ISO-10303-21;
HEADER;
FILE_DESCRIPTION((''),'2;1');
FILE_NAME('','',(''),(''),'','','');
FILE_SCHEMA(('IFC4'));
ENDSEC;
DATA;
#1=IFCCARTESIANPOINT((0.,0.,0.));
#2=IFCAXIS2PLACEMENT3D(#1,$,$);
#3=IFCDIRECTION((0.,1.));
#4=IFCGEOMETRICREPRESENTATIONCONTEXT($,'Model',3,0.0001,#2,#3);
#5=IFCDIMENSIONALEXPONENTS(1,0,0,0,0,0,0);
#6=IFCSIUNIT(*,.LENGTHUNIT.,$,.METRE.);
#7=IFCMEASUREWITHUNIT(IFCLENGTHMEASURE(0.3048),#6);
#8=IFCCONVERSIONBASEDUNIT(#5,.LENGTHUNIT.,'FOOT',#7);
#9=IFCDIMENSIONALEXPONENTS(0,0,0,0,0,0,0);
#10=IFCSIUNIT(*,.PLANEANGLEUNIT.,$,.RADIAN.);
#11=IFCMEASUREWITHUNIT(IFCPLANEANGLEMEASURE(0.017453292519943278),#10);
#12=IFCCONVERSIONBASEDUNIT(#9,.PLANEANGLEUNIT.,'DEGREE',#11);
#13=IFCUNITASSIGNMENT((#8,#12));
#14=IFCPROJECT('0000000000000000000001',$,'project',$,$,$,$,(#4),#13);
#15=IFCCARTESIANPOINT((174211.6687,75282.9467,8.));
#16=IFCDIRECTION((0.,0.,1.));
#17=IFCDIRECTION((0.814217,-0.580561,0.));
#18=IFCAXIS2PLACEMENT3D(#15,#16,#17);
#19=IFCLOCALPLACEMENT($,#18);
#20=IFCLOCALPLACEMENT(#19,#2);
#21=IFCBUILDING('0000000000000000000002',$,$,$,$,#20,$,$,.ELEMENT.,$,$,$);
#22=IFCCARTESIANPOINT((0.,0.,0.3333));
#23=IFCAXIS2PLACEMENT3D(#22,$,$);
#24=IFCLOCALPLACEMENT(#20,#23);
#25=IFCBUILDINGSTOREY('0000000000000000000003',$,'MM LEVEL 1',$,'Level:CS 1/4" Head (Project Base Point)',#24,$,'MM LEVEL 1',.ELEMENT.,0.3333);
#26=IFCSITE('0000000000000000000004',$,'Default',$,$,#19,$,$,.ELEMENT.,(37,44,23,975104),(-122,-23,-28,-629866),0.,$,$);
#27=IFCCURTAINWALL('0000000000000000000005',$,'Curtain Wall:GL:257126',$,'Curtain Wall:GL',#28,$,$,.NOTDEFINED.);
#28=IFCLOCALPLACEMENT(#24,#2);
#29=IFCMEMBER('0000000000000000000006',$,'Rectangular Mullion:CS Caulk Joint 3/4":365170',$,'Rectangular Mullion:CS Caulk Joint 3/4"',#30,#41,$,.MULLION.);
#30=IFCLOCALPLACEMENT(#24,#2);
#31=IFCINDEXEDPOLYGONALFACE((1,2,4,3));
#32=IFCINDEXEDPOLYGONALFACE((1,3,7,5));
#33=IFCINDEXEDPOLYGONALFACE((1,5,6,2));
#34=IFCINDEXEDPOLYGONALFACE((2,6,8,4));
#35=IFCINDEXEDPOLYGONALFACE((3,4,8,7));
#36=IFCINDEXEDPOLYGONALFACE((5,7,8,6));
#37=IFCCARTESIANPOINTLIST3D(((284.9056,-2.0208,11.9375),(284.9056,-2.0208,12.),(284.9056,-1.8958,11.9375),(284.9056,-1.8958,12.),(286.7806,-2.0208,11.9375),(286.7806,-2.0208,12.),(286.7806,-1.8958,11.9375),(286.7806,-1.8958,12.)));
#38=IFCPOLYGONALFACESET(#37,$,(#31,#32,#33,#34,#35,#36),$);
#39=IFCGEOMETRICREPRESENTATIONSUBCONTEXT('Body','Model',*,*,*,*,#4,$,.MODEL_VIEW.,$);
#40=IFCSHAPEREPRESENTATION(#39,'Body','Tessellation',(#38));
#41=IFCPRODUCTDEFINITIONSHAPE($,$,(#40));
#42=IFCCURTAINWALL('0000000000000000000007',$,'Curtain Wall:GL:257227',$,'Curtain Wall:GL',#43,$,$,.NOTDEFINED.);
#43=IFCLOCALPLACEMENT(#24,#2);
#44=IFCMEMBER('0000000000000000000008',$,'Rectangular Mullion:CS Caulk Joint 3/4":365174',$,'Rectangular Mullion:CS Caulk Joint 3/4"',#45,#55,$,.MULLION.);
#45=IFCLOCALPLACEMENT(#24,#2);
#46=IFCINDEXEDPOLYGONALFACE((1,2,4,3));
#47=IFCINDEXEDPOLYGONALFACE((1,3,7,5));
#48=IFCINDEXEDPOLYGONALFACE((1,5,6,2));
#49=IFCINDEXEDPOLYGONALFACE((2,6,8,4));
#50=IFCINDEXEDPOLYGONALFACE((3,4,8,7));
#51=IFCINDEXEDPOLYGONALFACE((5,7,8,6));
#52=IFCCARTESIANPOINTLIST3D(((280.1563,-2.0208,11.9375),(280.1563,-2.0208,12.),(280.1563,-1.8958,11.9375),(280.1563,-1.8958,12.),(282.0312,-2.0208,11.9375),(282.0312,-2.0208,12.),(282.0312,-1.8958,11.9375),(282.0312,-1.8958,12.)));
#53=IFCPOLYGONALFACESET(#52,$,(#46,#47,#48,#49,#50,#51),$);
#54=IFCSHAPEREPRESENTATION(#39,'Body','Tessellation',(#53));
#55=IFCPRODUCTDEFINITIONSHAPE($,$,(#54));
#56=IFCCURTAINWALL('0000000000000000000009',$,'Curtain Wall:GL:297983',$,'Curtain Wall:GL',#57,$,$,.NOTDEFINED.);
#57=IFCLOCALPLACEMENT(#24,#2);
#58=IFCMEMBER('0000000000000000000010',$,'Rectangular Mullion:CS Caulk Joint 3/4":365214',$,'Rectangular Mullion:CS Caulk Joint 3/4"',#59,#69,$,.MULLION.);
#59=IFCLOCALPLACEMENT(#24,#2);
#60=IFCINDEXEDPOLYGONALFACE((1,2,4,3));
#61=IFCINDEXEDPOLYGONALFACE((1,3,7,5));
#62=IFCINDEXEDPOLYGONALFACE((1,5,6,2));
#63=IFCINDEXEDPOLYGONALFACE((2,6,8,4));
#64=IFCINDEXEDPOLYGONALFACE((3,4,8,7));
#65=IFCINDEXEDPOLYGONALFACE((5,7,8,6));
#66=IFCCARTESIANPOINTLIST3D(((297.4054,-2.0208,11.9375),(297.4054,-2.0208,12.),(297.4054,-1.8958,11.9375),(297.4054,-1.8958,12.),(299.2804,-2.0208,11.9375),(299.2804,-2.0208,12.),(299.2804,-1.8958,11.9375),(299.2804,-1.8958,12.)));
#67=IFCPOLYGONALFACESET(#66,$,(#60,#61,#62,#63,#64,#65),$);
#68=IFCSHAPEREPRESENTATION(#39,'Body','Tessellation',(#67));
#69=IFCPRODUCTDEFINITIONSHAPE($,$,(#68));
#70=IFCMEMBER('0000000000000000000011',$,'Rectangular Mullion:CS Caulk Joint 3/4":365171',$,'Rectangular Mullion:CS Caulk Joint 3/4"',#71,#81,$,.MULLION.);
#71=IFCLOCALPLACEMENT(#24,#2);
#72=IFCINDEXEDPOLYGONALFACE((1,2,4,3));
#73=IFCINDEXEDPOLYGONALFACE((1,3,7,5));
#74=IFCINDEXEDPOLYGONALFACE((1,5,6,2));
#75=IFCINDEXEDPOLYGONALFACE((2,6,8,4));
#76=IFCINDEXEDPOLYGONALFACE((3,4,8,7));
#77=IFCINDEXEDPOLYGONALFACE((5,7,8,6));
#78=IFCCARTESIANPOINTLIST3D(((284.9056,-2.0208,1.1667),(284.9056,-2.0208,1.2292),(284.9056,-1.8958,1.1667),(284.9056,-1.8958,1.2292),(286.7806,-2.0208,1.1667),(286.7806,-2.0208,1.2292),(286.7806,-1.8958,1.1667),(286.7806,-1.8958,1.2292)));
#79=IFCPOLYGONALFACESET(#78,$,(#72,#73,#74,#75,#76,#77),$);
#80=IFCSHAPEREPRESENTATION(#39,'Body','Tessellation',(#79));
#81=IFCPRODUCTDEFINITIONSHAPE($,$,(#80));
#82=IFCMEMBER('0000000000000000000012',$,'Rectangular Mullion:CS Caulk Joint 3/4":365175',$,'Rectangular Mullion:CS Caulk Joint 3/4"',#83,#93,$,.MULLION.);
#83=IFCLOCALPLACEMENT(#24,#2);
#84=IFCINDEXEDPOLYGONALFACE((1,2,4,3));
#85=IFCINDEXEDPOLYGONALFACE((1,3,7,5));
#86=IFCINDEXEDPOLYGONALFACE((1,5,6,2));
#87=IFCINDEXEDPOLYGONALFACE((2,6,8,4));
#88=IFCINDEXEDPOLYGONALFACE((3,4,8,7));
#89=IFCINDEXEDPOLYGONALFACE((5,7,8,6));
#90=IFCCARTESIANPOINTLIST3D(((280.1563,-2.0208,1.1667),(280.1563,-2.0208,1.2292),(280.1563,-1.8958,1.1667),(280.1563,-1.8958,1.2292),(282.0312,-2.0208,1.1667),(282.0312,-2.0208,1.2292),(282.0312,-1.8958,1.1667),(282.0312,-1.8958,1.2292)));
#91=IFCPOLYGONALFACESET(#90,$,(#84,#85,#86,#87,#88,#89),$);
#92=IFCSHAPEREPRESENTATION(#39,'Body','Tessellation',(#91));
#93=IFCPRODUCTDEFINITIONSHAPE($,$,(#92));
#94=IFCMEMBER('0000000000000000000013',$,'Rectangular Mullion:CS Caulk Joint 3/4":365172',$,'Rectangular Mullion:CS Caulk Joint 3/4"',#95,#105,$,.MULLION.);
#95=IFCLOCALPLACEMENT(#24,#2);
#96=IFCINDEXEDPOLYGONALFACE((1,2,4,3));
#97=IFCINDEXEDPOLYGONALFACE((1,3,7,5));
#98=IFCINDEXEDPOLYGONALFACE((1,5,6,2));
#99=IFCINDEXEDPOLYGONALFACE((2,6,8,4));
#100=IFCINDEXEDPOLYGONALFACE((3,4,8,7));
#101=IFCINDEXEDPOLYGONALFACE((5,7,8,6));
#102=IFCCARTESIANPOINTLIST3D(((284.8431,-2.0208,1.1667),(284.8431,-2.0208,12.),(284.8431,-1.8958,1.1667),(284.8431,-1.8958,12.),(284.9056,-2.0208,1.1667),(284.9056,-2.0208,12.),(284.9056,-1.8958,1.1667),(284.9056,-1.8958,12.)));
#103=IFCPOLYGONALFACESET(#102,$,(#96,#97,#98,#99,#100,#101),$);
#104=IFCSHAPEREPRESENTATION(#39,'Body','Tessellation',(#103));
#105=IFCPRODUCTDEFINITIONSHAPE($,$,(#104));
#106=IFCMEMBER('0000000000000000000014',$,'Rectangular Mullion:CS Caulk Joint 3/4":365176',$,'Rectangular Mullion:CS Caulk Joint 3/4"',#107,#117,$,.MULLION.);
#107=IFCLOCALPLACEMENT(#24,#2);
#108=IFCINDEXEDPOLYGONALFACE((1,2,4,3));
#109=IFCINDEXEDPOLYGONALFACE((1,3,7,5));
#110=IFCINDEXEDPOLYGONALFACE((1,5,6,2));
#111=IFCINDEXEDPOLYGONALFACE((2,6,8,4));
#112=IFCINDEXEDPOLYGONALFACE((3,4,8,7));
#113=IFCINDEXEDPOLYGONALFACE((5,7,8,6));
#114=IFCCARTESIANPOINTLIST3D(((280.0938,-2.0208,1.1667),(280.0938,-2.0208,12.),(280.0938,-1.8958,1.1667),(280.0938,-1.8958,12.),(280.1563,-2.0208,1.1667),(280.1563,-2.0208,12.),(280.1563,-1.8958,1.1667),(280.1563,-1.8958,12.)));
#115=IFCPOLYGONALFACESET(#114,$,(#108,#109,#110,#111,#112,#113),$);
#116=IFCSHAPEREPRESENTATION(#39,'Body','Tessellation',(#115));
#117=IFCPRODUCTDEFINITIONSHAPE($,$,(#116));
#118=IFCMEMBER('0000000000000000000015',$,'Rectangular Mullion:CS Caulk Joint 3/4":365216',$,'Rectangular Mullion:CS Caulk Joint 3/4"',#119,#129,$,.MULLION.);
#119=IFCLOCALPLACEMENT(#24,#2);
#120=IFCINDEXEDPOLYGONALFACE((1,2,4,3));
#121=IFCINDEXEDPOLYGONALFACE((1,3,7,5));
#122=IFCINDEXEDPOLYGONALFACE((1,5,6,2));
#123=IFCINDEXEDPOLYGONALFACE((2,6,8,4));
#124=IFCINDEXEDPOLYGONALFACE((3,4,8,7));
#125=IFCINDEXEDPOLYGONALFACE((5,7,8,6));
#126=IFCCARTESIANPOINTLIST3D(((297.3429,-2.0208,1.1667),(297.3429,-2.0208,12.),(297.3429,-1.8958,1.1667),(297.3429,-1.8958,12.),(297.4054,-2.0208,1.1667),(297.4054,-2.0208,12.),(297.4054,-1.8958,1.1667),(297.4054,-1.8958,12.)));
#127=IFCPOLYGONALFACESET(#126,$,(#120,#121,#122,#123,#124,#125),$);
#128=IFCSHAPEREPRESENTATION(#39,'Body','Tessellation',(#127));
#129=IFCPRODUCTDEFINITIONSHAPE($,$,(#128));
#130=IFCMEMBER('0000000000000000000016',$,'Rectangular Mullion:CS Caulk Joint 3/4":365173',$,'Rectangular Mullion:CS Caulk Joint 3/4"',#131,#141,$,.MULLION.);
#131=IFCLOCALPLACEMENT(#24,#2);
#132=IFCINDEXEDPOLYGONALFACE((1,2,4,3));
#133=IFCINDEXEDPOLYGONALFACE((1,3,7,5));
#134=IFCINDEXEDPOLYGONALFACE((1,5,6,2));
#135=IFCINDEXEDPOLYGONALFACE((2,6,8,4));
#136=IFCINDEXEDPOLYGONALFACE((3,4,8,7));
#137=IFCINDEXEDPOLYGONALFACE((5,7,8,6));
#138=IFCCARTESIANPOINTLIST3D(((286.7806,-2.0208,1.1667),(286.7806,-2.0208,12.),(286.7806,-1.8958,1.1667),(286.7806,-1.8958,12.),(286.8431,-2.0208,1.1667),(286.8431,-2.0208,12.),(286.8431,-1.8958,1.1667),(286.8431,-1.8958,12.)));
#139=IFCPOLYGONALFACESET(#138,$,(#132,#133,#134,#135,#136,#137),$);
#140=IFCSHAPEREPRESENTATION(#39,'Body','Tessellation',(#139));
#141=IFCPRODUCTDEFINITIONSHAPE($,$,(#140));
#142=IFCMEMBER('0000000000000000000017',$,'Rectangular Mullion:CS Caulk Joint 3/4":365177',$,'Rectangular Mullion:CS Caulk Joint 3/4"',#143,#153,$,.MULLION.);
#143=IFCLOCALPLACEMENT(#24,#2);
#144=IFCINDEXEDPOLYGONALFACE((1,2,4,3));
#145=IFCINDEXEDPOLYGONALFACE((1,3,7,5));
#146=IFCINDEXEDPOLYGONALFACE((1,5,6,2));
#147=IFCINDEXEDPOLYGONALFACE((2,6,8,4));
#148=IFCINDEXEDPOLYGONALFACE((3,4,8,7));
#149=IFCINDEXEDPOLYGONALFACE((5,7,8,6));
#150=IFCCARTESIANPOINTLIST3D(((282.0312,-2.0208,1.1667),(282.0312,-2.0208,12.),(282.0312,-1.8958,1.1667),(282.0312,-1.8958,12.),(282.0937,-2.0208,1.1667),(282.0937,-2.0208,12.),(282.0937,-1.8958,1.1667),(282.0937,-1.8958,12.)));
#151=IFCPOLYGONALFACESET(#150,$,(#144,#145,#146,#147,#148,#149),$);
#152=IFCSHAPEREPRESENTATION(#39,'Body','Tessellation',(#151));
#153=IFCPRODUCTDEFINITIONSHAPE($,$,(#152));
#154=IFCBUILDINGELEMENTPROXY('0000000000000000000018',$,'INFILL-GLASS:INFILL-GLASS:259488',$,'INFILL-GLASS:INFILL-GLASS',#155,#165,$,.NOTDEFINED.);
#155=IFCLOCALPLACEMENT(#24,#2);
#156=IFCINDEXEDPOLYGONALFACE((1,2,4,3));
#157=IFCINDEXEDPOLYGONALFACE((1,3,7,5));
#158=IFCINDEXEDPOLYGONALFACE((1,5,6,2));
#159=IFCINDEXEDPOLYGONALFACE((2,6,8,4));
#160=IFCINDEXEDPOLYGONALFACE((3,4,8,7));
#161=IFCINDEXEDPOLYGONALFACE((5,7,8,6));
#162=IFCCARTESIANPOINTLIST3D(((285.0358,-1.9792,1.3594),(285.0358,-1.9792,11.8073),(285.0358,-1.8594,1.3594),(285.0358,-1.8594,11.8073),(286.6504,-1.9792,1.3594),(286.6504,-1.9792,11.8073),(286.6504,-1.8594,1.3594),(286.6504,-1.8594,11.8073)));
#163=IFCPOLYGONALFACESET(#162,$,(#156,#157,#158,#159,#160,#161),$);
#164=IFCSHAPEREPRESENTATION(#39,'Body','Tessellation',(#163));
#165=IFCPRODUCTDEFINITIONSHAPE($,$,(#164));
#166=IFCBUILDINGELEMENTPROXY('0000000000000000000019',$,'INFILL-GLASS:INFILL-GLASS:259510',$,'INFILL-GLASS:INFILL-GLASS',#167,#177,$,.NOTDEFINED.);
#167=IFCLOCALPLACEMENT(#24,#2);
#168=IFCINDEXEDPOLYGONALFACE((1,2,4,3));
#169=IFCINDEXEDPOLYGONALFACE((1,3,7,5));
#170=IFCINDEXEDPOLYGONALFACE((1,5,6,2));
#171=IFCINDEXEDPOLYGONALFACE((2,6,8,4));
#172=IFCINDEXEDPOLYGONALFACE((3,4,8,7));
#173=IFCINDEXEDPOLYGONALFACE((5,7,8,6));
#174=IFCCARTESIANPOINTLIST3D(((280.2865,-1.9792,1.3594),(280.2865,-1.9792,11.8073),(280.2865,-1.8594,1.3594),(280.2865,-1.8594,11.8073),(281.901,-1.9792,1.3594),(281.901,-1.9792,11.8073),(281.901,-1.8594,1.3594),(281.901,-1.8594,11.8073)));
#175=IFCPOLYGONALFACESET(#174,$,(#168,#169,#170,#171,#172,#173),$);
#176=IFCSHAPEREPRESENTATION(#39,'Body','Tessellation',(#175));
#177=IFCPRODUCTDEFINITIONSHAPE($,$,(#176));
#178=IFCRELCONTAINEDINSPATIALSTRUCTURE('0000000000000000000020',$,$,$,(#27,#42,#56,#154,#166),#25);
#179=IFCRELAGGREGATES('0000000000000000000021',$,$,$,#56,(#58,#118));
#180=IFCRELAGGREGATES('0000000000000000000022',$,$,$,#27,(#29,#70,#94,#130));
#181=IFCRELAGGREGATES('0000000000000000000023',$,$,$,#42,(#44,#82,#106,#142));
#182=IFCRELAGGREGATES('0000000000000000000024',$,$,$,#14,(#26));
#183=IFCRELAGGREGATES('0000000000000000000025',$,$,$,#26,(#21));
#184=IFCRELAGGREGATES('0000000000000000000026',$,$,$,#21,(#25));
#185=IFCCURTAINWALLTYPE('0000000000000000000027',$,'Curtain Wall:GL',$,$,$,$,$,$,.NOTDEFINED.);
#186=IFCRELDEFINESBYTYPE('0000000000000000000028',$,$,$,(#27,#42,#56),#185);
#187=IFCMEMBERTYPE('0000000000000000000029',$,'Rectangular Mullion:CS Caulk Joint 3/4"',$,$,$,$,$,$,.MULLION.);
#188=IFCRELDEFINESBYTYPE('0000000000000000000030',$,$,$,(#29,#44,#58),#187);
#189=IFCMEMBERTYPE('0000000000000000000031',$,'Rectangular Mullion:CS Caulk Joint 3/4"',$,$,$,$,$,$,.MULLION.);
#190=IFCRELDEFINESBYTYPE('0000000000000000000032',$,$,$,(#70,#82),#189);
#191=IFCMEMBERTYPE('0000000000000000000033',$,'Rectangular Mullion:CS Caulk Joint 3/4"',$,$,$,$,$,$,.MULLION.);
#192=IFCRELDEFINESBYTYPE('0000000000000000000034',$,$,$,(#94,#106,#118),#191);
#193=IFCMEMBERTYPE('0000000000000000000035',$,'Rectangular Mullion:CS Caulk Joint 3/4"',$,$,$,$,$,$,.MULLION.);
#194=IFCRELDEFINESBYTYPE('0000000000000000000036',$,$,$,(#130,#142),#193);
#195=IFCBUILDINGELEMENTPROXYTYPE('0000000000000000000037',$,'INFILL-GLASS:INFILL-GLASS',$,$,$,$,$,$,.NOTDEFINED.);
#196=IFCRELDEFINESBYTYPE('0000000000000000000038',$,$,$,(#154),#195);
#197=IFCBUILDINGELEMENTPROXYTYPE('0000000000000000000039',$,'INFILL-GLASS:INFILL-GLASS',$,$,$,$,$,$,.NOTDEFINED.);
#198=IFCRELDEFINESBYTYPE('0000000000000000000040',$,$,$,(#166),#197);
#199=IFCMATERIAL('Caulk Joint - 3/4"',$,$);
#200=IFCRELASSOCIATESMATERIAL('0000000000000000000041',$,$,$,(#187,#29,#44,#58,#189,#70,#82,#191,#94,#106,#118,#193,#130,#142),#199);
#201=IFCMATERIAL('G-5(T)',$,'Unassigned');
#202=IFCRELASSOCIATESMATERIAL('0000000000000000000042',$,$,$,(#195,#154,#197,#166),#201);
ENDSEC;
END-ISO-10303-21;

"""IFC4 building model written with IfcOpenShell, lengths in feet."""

from ifc_helpers import new_model, entity, si_unit, converted_unit, direction, frame, origin, place, context, subcontext, project, spatial, indexed_curve, outline, extrude, source, transform, mapped, material, type_object, type_shapes, element, aggregate, save


model = new_model("IFC4")

# Units and contexts
model_context = context("Model", 3, precision=0.0001, world=origin(), true_north=direction((0.0, 1.0)))
body_context = subcontext(model_context, "Body", "Model", "MODEL_VIEW")
ifc_project = project(units=[converted_unit("LENGTHUNIT", "FOOT", entity("IfcLengthMeasure", 0.3048), si_unit("LENGTHUNIT", "METRE"), dimensions=[1, 0, 0, 0, 0, 0, 0]), converted_unit("PLANEANGLEUNIT", "DEGREE", entity("IfcPlaneAngleMeasure", 0.017453292519943278), si_unit("PLANEANGLEUNIT", "RADIAN"), dimensions=[0, 0, 0, 0, 0, 0, 0])], contexts=[model_context])

# Site, building, storey
site_placement = place(None, frame((174211.6687, 75282.9467, 8.0), z_axis=(0.0, 0.0, 1.0), x_axis=(0.814217, -0.580561, 0.0)))
site = spatial("IfcSite", under=ifc_project, at=site_placement, Name="Default", CompositionType="ELEMENT", RefLatitude=(37, 44, 23, 975104), RefLongitude=(-122, -23, -28, -629866), RefElevation=0.0)
building_placement = place(site_placement, origin())
building = spatial("IfcBuilding", under=site, at=building_placement, CompositionType="ELEMENT")
storey_placement = place(building_placement, frame((0.0, 0.0, 0.3333)))
storey = spatial("IfcBuildingStorey", under=building, at=storey_placement, Name="MM LEVEL 1", ObjectType="Level:CS 1/4\" Head (Project Base Point)", LongName="MM LEVEL 1", CompositionType="ELEMENT", Elevation=0.3333)

# Curtain walls, members
curtain_wall_type_1 = type_object("IfcCurtainWallType", Name="Curtain Wall:GL", PredefinedType="NOTDEFINED")
curtain_wall_1_placement = place(storey_placement, frame((0.0, 0.0, -0.3333)))
curtain_wall_1 = element("IfcCurtainWall", 1, at=curtain_wall_1_placement, inside=storey, type_object=curtain_wall_type_1, Name="Curtain Wall:GL:257126", ObjectType="Curtain Wall:GL", PredefinedType="NOTDEFINED")
ifc_material_1 = material(Name="Caulk Joint - 3/4\"")
member_type_1 = type_object("IfcMemberType", Name="Rectangular Mullion:CS Caulk Joint 3/4\"", PredefinedType="MULLION", material=ifc_material_1)
shared_shape_1 = source(origin(), body_context, "Body", "SweptSolid", [
    extrude(outline(indexed_curve([(-0.0625, -0.0312), (0.0625, -0.0312), (0.0625, 0.0312), (-0.0625, 0.0312), (-0.0625, -0.0312)], self_intersect=False)), frame((-0.0312, 0.0625, -1.875), z_axis=(0.0, 0.0, 1.0), x_axis=(0.0, -1.0, 0.0)), (0.0, 0.0, 1.0), 1.875),
])
type_shapes(member_type_1, [shared_shape_1])
member_1_placement = place(curtain_wall_1_placement, frame((284.9056, -2.0208, 12.3333), z_axis=(-1.0, 0.0, 0.0), x_axis=(0.0, 0.0, 1.0)))
member_1 = element("IfcMember", 2, at=member_1_placement, type_object=member_type_1, material=ifc_material_1, Name="Rectangular Mullion:CS Caulk Joint 3/4\":365170", ObjectType="Rectangular Mullion:CS Caulk Joint 3/4\"", PredefinedType="MULLION", context=body_context, shape_type="MappedRepresentation", body=[
    mapped(shared_shape_1, transform((0.0, 0.0, 0.0), scale=1.0)),
])
curtain_wall_2_placement = place(storey_placement, frame((0.0, 0.0, -0.3333)))
curtain_wall_2 = element("IfcCurtainWall", 3, at=curtain_wall_2_placement, inside=storey, type_object=curtain_wall_type_1, Name="Curtain Wall:GL:257227", ObjectType="Curtain Wall:GL", PredefinedType="NOTDEFINED")
member_2_placement = place(curtain_wall_2_placement, frame((280.1562, -2.0208, 12.3333), z_axis=(-1.0, 0.0, 0.0), x_axis=(0.0, 0.0, 1.0)))
member_2 = element("IfcMember", 4, at=member_2_placement, type_object=member_type_1, material=ifc_material_1, Name="Rectangular Mullion:CS Caulk Joint 3/4\":365174", ObjectType="Rectangular Mullion:CS Caulk Joint 3/4\"", PredefinedType="MULLION", context=body_context, shape_type="MappedRepresentation", body=[
    mapped(shared_shape_1, transform((0.0, 0.0, 0.0), scale=1.0)),
])
curtain_wall_3_placement = place(storey_placement, frame((0.0, 0.0, -0.3333)))
curtain_wall_3 = element("IfcCurtainWall", 5, at=curtain_wall_3_placement, inside=storey, type_object=curtain_wall_type_1, Name="Curtain Wall:GL:297983", ObjectType="Curtain Wall:GL", PredefinedType="NOTDEFINED")
member_3_placement = place(curtain_wall_3_placement, frame((297.4054, -2.0208, 12.3333), z_axis=(-1.0, 0.0, 0.0), x_axis=(0.0, 0.0, 1.0)))
member_3 = element("IfcMember", 6, at=member_3_placement, type_object=member_type_1, material=ifc_material_1, Name="Rectangular Mullion:CS Caulk Joint 3/4\":365214", ObjectType="Rectangular Mullion:CS Caulk Joint 3/4\"", PredefinedType="MULLION", context=body_context, shape_type="MappedRepresentation", body=[
    mapped(shared_shape_1, transform((0.0, 0.0, 0.0), scale=1.0)),
])

# Members
member_type_2 = type_object("IfcMemberType", Name="Rectangular Mullion:CS Caulk Joint 3/4\"", PredefinedType="MULLION", material=ifc_material_1)
shared_shape_2 = source(origin(), body_context, "Body", "SweptSolid", [
    extrude(outline(indexed_curve([(-0.0312, -0.0625), (0.0312, -0.0625), (0.0312, 0.0625), (-0.0312, 0.0625), (-0.0312, -0.0625)], self_intersect=False)), frame((-0.0312, 0.0625, -1.875), z_axis=(0.0, 0.0, 1.0), x_axis=(-1.0, 0.0, 0.0)), (0.0, 0.0, 1.0), 1.875),
])
type_shapes(member_type_2, [shared_shape_2])
member_4_placement = place(curtain_wall_1_placement, frame((286.7806, -2.0208, 1.5), z_axis=(1.0, 0.0, 0.0), x_axis=(0.0, 0.0, -1.0)))
member_4 = element("IfcMember", 7, at=member_4_placement, type_object=member_type_2, material=ifc_material_1, Name="Rectangular Mullion:CS Caulk Joint 3/4\":365171", ObjectType="Rectangular Mullion:CS Caulk Joint 3/4\"", PredefinedType="MULLION", context=body_context, shape_type="MappedRepresentation", body=[
    mapped(shared_shape_2, transform((0.0, 0.0, 0.0), scale=1.0)),
])
member_5_placement = place(curtain_wall_2_placement, frame((282.0312, -2.0208, 1.5), z_axis=(1.0, 0.0, 0.0), x_axis=(0.0, 0.0, -1.0)))
member_5 = element("IfcMember", 8, at=member_5_placement, type_object=member_type_2, material=ifc_material_1, Name="Rectangular Mullion:CS Caulk Joint 3/4\":365175", ObjectType="Rectangular Mullion:CS Caulk Joint 3/4\"", PredefinedType="MULLION", context=body_context, shape_type="MappedRepresentation", body=[
    mapped(shared_shape_2, transform((0.0, 0.0, 0.0), scale=1.0)),
])
member_type_3 = type_object("IfcMemberType", Name="Rectangular Mullion:CS Caulk Joint 3/4\"", PredefinedType="MULLION", material=ifc_material_1)
shared_shape_3 = source(origin(), body_context, "Body", "SweptSolid", [
    extrude(outline(indexed_curve([(-0.0625, -0.0312), (0.0625, -0.0312), (0.0625, 0.0312), (-0.0625, 0.0312), (-0.0625, -0.0312)], self_intersect=False)), frame((-0.0312, 0.0625, -10.8333), z_axis=(0.0, 0.0, 1.0), x_axis=(0.0, -1.0, 0.0)), (0.0, 0.0, 1.0), 10.8333),
])
type_shapes(member_type_3, [shared_shape_3])
member_6_placement = place(curtain_wall_1_placement, frame((284.8431, -2.0208, 1.5), z_axis=(0.0, 0.0, -1.0), x_axis=(-1.0, 0.0, 0.0)))
member_6 = element("IfcMember", 9, at=member_6_placement, type_object=member_type_3, material=ifc_material_1, Name="Rectangular Mullion:CS Caulk Joint 3/4\":365172", ObjectType="Rectangular Mullion:CS Caulk Joint 3/4\"", PredefinedType="MULLION", context=body_context, shape_type="MappedRepresentation", body=[
    mapped(shared_shape_3, transform((0.0, 0.0, 0.0), scale=1.0)),
])
member_7_placement = place(curtain_wall_2_placement, frame((280.0938, -2.0208, 1.5), z_axis=(0.0, 0.0, -1.0), x_axis=(-1.0, 0.0, 0.0)))
member_7 = element("IfcMember", 10, at=member_7_placement, type_object=member_type_3, material=ifc_material_1, Name="Rectangular Mullion:CS Caulk Joint 3/4\":365176", ObjectType="Rectangular Mullion:CS Caulk Joint 3/4\"", PredefinedType="MULLION", context=body_context, shape_type="MappedRepresentation", body=[
    mapped(shared_shape_3, transform((0.0, 0.0, 0.0), scale=1.0)),
])
member_8_placement = place(curtain_wall_3_placement, frame((297.3429, -2.0208, 1.5), z_axis=(0.0, 0.0, -1.0), x_axis=(-1.0, 0.0, 0.0)))
member_8 = element("IfcMember", 11, at=member_8_placement, type_object=member_type_3, material=ifc_material_1, Name="Rectangular Mullion:CS Caulk Joint 3/4\":365216", ObjectType="Rectangular Mullion:CS Caulk Joint 3/4\"", PredefinedType="MULLION", context=body_context, shape_type="MappedRepresentation", body=[
    mapped(shared_shape_3, transform((0.0, 0.0, 0.0), scale=1.0)),
])
aggregate(curtain_wall_3, [member_3, member_8])
member_type_4 = type_object("IfcMemberType", Name="Rectangular Mullion:CS Caulk Joint 3/4\"", PredefinedType="MULLION", material=ifc_material_1)
shared_shape_4 = source(origin(), body_context, "Body", "SweptSolid", [
    extrude(outline(indexed_curve([(-0.0312, -0.0625), (0.0312, -0.0625), (0.0312, 0.0625), (-0.0312, 0.0625), (-0.0312, -0.0625)], self_intersect=False)), frame((-0.0312, 0.0625, -10.8333), z_axis=(0.0, 0.0, 1.0), x_axis=(-1.0, 0.0, 0.0)), (0.0, 0.0, 1.0), 10.8333),
])
type_shapes(member_type_4, [shared_shape_4])
member_9_placement = place(curtain_wall_1_placement, frame((286.8431, -2.0208, 12.3333)))
member_9 = element("IfcMember", 12, at=member_9_placement, type_object=member_type_4, material=ifc_material_1, Name="Rectangular Mullion:CS Caulk Joint 3/4\":365173", ObjectType="Rectangular Mullion:CS Caulk Joint 3/4\"", PredefinedType="MULLION", context=body_context, shape_type="MappedRepresentation", body=[
    mapped(shared_shape_4, transform((0.0, 0.0, 0.0), scale=1.0)),
])
aggregate(curtain_wall_1, [member_1, member_4, member_6, member_9])
member_10_placement = place(curtain_wall_2_placement, frame((282.0937, -2.0208, 12.3333)))
member_10 = element("IfcMember", 13, at=member_10_placement, type_object=member_type_4, material=ifc_material_1, Name="Rectangular Mullion:CS Caulk Joint 3/4\":365177", ObjectType="Rectangular Mullion:CS Caulk Joint 3/4\"", PredefinedType="MULLION", context=body_context, shape_type="MappedRepresentation", body=[
    mapped(shared_shape_4, transform((0.0, 0.0, 0.0), scale=1.0)),
])
aggregate(curtain_wall_2, [member_2, member_5, member_7, member_10])

# Building element proxies
ifc_material_2 = material(Name="G-5(T)", Category="Unassigned")
building_element_proxy_type_1 = type_object("IfcBuildingElementProxyType", Name="INFILL-GLASS:INFILL-GLASS", PredefinedType="NOTDEFINED", material=ifc_material_2)
shared_shape_5 = source(origin(), body_context, "Body", "SweptSolid", [
    extrude(outline(indexed_curve([(-0.0599, -0.8073), (0.0599, -0.8073), (0.0599, 0.8073), (-0.0599, 0.8073), (-0.0599, -0.8073)], self_intersect=False)), frame((0.0, 0.1016, 0.1302), z_axis=(0.0, 0.0, 1.0), x_axis=(0.0, 1.0, 0.0)), (0.0, 0.0, 1.0), 10.4479),
])
type_shapes(building_element_proxy_type_1, [shared_shape_5])
proxy_1_placement = place(storey_placement, frame((285.8431, -2.0208, 1.2292)))
element("IfcBuildingElementProxy", 14, at=proxy_1_placement, inside=storey, type_object=building_element_proxy_type_1, material=ifc_material_2, Name="INFILL-GLASS:INFILL-GLASS:259488", ObjectType="INFILL-GLASS:INFILL-GLASS", PredefinedType="NOTDEFINED", context=body_context, shape_type="MappedRepresentation", body=[
    mapped(shared_shape_5, transform((0.0, 0.0, 0.0), scale=1.0)),
])
building_element_proxy_type_2 = type_object("IfcBuildingElementProxyType", Name="INFILL-GLASS:INFILL-GLASS", PredefinedType="NOTDEFINED", material=ifc_material_2)
shared_shape_6 = source(origin(), body_context, "Body", "SweptSolid", [
    extrude(outline(indexed_curve([(-0.0599, -0.8073), (0.0599, -0.8073), (0.0599, 0.8073), (-0.0599, 0.8073), (-0.0599, -0.8073)], self_intersect=False)), frame((0.0, 0.1016, 0.1302), z_axis=(0.0, 0.0, 1.0), x_axis=(0.0, 1.0, 0.0)), (0.0, 0.0, 1.0), 10.4479),
])
type_shapes(building_element_proxy_type_2, [shared_shape_6])
proxy_2_placement = place(storey_placement, frame((281.0937, -2.0208, 1.2292)))
element("IfcBuildingElementProxy", 15, at=proxy_2_placement, inside=storey, type_object=building_element_proxy_type_2, material=ifc_material_2, Name="INFILL-GLASS:INFILL-GLASS:259510", ObjectType="INFILL-GLASS:INFILL-GLASS", PredefinedType="NOTDEFINED", context=body_context, shape_type="MappedRepresentation", body=[
    mapped(shared_shape_6, transform((0.0, 0.0, 0.0), scale=1.0)),
])

save(model, "model.ifc")
